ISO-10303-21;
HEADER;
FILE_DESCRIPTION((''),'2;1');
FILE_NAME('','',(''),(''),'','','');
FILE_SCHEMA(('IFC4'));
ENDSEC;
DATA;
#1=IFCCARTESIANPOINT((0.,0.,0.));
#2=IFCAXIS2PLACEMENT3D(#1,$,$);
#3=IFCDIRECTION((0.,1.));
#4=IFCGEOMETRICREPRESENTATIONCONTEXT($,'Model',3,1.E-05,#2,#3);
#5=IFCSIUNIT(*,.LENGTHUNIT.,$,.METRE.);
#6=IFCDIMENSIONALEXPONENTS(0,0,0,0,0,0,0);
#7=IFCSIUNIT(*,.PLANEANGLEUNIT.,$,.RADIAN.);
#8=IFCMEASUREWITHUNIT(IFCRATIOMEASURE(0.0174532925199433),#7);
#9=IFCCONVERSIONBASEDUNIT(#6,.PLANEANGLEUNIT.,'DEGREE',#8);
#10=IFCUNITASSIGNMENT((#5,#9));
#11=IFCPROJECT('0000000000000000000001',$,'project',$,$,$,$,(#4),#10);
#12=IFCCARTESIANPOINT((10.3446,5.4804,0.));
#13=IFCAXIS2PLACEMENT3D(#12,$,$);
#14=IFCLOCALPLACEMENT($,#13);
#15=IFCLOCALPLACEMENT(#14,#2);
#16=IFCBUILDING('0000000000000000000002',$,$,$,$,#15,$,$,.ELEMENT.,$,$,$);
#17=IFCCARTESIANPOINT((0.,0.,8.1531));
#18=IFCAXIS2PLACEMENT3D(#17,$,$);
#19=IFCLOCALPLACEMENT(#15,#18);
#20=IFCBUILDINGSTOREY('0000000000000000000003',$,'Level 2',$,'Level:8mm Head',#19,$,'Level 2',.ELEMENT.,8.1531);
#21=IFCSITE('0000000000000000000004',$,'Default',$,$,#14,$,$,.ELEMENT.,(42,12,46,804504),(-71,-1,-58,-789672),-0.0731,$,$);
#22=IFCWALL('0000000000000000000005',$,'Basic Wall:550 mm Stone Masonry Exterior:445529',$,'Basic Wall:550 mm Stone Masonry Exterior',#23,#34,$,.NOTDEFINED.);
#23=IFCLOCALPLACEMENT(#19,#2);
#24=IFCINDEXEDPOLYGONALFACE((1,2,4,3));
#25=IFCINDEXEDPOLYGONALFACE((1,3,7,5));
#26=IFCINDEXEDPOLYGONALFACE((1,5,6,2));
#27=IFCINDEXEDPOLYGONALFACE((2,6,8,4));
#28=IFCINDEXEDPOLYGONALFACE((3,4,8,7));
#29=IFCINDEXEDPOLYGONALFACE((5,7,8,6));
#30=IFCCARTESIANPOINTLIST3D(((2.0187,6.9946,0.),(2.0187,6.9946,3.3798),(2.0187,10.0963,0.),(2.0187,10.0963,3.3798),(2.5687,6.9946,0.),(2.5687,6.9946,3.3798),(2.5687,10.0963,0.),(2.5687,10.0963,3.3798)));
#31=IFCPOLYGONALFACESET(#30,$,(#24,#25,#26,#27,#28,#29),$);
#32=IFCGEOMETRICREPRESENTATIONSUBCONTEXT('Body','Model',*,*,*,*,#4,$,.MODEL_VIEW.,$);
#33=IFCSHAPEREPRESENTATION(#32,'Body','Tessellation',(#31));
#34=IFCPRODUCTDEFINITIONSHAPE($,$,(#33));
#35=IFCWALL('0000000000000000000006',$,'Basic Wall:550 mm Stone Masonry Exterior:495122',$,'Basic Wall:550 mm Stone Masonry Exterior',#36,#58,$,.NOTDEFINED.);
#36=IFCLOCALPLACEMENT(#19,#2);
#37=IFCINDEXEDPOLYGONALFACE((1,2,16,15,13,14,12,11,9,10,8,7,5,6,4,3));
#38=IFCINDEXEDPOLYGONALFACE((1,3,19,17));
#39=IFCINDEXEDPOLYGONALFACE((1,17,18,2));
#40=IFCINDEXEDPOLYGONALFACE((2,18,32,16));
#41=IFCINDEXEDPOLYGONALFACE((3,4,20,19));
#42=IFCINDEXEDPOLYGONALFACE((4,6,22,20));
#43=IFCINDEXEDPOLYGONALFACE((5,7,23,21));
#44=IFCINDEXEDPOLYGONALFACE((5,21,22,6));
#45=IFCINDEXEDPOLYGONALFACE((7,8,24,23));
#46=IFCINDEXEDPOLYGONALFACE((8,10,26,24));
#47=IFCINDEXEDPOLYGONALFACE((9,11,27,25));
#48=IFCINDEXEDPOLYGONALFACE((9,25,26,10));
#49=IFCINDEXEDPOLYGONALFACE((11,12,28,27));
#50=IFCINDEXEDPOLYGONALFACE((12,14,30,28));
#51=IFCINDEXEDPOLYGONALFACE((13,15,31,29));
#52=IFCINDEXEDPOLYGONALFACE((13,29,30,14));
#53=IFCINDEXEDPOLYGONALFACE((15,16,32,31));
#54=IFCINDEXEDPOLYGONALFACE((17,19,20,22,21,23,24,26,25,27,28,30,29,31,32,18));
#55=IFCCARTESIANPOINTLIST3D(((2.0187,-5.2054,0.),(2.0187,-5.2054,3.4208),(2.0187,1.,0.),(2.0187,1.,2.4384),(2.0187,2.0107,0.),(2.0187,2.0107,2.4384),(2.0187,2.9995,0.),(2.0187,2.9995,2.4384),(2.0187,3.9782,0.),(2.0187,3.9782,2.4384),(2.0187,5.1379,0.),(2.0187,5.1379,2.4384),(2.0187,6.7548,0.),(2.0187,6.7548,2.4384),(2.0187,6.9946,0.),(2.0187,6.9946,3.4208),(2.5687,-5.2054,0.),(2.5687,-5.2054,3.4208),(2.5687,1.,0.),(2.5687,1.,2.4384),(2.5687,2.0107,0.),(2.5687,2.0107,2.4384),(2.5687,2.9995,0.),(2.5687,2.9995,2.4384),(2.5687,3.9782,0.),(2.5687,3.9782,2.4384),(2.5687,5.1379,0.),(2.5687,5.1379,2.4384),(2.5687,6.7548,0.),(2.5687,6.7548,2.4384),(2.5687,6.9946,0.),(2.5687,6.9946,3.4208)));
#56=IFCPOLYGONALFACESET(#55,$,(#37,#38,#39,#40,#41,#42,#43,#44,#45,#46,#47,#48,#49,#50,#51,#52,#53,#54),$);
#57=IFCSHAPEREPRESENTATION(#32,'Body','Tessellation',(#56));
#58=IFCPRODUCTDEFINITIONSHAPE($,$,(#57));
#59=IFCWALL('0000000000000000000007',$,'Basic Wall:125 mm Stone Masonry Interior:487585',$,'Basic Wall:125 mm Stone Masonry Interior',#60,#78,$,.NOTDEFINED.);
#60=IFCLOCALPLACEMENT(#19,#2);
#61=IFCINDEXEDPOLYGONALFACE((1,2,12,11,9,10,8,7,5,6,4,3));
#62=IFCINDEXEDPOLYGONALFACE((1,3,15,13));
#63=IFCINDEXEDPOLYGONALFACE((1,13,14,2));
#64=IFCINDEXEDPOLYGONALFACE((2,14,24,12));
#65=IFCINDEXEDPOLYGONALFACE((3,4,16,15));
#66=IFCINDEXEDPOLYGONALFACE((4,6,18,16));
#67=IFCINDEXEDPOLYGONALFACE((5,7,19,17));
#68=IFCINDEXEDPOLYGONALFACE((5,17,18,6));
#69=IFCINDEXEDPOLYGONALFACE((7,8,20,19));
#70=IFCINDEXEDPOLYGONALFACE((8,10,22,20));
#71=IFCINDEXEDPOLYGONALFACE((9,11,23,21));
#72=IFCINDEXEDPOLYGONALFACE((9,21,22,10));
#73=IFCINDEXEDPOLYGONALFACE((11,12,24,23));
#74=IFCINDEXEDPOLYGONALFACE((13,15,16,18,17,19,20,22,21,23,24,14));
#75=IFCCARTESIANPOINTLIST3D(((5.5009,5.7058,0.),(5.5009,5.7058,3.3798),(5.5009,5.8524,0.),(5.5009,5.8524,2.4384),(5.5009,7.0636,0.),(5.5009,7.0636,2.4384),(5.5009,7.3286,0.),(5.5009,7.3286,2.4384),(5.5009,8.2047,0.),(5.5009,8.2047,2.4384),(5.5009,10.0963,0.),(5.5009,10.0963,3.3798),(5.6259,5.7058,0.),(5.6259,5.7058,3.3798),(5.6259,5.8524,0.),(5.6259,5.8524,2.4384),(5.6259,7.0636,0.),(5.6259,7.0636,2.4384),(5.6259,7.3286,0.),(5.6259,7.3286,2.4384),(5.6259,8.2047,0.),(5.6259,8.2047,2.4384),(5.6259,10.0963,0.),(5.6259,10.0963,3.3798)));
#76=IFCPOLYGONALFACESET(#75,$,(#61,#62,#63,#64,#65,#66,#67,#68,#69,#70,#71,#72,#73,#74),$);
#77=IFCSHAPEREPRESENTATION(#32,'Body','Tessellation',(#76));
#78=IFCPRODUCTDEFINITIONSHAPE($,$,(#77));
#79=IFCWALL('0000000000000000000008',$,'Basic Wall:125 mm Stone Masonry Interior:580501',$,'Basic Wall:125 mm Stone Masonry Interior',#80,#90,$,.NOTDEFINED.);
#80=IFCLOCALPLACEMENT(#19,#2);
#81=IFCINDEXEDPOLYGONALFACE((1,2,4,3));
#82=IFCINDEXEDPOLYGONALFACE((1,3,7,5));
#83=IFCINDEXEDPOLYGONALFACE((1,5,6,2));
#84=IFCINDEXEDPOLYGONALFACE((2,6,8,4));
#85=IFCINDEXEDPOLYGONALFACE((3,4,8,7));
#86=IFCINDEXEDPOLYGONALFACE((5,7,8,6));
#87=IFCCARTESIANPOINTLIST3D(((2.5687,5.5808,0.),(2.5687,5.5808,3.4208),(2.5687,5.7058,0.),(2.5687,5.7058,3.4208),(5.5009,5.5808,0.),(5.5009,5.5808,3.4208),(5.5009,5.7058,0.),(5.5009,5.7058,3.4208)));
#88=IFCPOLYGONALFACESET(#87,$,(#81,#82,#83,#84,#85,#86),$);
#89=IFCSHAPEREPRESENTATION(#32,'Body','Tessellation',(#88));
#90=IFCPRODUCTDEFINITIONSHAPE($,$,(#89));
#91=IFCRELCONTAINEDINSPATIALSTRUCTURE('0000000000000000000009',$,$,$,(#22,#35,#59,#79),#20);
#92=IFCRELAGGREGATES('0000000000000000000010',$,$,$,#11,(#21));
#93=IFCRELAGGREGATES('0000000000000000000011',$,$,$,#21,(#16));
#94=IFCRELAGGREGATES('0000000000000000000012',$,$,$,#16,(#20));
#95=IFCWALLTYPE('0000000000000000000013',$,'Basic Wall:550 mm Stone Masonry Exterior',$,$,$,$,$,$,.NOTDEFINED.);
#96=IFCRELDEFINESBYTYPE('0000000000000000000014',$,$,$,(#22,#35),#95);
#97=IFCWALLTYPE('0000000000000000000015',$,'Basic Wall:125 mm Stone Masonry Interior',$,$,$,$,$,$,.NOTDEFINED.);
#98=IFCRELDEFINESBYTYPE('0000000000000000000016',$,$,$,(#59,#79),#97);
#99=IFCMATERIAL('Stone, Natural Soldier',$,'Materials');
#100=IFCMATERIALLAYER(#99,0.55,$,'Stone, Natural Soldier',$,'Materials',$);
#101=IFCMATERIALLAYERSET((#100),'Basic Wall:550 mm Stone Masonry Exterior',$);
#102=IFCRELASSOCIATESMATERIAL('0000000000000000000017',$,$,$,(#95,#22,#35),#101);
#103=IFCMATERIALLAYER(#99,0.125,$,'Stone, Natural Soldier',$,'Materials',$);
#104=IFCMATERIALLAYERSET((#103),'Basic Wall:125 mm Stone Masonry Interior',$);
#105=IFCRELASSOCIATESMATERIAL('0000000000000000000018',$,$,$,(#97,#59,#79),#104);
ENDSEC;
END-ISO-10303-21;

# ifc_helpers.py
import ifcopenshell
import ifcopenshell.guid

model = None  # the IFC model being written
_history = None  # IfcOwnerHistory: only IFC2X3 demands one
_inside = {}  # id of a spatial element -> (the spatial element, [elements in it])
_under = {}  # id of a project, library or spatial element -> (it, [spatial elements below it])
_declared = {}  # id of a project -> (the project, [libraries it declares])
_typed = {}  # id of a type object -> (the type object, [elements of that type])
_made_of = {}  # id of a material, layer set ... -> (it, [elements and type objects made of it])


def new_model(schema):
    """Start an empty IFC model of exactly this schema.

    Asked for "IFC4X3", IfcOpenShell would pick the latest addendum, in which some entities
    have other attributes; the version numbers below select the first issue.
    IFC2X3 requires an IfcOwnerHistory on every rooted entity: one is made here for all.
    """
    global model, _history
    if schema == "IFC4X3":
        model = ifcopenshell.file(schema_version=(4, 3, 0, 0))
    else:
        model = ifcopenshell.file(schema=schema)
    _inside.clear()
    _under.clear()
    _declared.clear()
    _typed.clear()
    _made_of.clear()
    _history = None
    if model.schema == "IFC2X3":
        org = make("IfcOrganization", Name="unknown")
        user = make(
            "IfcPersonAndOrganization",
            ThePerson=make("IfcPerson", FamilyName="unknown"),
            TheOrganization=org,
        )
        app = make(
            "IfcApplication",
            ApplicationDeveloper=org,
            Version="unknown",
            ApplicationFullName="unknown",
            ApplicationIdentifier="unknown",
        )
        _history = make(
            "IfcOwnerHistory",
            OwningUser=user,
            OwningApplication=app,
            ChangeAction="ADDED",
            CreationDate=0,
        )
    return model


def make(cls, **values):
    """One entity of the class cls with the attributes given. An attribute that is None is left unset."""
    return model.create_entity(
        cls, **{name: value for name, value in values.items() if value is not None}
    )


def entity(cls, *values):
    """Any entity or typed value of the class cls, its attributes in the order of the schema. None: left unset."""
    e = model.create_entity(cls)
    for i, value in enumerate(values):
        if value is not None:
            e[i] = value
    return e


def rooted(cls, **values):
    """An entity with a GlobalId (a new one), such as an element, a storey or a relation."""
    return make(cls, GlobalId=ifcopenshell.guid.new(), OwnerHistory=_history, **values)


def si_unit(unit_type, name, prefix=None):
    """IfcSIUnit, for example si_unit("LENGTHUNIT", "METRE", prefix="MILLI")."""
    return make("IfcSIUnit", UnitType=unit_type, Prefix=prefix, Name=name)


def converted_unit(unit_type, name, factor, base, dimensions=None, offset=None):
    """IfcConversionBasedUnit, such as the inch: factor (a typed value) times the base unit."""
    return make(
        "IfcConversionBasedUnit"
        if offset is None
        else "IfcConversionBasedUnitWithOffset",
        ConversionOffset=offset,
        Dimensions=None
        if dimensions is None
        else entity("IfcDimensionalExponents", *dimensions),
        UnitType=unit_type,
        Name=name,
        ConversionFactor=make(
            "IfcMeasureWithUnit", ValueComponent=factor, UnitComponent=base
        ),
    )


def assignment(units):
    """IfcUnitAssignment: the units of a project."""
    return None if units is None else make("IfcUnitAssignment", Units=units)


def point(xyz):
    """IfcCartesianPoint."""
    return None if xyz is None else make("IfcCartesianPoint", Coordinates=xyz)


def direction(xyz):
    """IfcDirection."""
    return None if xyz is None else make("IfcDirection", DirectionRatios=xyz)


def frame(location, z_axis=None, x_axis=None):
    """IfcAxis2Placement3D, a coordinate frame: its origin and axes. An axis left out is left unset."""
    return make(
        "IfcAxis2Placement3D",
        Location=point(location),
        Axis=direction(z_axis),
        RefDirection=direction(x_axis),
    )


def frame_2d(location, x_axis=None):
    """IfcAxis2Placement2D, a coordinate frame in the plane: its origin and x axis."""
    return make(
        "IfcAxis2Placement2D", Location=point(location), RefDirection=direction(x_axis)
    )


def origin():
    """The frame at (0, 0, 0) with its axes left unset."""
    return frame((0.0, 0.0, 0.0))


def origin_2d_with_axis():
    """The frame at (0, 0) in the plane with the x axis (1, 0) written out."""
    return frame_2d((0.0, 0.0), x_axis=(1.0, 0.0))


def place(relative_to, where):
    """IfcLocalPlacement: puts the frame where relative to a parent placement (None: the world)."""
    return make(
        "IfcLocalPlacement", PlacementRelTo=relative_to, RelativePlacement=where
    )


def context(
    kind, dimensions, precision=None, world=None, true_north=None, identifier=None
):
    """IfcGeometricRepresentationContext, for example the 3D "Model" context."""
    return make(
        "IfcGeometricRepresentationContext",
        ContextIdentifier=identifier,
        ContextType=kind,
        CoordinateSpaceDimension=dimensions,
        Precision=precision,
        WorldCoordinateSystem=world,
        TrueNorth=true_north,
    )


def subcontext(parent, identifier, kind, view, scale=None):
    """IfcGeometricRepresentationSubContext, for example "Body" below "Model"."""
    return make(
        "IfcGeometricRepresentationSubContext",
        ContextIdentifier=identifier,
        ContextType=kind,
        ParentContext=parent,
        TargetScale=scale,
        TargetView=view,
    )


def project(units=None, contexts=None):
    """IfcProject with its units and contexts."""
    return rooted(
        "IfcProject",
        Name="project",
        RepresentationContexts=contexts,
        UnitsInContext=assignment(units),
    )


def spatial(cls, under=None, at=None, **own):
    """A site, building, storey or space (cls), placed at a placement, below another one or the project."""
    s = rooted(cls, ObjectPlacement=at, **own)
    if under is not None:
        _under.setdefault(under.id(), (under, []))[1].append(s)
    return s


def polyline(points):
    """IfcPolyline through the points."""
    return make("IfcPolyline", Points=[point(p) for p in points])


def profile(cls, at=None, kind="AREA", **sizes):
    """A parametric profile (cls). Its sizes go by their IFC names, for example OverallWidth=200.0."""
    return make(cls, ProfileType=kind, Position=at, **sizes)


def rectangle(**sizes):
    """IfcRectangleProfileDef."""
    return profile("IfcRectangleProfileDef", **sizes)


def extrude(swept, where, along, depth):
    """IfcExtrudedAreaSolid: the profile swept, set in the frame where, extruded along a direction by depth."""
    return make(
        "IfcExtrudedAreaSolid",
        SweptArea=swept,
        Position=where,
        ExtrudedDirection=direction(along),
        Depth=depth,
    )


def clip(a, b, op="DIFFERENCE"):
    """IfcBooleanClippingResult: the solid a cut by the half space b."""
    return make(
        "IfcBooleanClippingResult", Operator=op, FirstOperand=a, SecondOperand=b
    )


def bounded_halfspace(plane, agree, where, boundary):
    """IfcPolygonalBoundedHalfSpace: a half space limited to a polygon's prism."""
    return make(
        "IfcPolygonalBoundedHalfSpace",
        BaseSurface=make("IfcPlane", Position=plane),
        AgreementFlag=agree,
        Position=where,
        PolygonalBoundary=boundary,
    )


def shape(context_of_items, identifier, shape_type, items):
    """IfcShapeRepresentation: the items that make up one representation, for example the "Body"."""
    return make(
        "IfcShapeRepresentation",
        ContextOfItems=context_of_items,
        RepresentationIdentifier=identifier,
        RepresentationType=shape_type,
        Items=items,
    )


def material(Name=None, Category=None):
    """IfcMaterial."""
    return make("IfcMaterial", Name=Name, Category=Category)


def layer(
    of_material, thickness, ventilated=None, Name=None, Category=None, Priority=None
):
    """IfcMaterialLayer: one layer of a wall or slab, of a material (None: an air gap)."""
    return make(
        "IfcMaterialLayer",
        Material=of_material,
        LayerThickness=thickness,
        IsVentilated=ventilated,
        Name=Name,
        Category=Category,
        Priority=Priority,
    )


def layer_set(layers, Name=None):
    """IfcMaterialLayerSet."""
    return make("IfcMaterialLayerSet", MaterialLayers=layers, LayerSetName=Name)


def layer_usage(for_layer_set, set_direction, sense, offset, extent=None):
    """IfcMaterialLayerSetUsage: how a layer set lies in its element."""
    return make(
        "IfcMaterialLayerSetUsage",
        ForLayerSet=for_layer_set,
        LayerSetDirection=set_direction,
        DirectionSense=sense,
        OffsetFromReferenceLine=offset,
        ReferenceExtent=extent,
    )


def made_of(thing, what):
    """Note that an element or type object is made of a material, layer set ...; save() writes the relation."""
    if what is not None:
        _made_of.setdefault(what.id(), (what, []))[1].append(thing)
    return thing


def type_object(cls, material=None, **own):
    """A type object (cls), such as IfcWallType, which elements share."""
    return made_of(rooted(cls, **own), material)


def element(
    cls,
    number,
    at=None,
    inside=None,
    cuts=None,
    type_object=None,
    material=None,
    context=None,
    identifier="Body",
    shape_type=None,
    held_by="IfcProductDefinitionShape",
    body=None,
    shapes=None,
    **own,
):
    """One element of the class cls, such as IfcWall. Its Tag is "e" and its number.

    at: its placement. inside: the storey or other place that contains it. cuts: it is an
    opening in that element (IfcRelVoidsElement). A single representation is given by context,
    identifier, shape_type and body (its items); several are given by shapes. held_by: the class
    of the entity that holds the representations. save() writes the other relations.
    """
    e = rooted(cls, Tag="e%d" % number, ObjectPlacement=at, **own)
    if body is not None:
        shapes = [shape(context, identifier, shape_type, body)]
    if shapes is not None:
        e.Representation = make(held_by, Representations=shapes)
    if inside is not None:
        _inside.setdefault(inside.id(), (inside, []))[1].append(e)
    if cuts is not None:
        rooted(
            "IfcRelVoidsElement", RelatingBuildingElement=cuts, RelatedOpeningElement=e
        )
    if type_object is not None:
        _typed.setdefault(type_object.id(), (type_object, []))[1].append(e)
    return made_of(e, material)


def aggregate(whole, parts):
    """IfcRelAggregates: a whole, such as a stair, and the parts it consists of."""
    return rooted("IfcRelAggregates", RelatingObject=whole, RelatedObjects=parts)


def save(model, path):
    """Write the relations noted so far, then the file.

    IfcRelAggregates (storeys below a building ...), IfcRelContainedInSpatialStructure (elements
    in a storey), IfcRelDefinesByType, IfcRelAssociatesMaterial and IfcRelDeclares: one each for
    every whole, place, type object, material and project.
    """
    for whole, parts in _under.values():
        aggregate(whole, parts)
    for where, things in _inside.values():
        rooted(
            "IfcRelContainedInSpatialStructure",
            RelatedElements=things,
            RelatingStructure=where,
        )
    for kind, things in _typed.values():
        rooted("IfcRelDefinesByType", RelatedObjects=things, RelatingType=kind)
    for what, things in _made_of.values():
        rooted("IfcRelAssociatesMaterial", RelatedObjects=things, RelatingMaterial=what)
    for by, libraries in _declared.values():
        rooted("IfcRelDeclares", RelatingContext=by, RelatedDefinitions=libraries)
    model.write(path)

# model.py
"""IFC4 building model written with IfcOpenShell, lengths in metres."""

from ifc_helpers import new_model, entity, si_unit, converted_unit, direction, frame, frame_2d, origin, origin_2d_with_axis, place, context, subcontext, project, spatial, polyline, rectangle, extrude, clip, bounded_halfspace, material, layer, layer_set, layer_usage, type_object, element, save


model = new_model("IFC4")

# Units and contexts
model_context = context("Model", 3, precision=1e-05, world=origin(), true_north=direction((0.0, 1.0)))
body_context = subcontext(model_context, "Body", "Model", "MODEL_VIEW")
ifc_project = project(units=[si_unit("LENGTHUNIT", "METRE"), converted_unit("PLANEANGLEUNIT", "DEGREE", entity("IfcRatioMeasure", 0.0174532925199433), si_unit("PLANEANGLEUNIT", "RADIAN"), dimensions=[0, 0, 0, 0, 0, 0, 0])], contexts=[model_context])

# Site, building, storey
site_placement = place(None, frame((10.3446, 5.4804, 0.0)))
site = spatial("IfcSite", under=ifc_project, at=site_placement, Name="Default", CompositionType="ELEMENT", RefLatitude=(42, 12, 46, 804504), RefLongitude=(-71, -1, -58, -789672), RefElevation=-0.0731)
building_placement = place(site_placement, origin())
building = spatial("IfcBuilding", under=site, at=building_placement, CompositionType="ELEMENT")
storey_placement = place(building_placement, frame((0.0, 0.0, 8.1531)))
storey = spatial("IfcBuildingStorey", under=building, at=storey_placement, Name="Level 2", ObjectType="Level:8mm Head", LongName="Level 2", CompositionType="ELEMENT", Elevation=8.1531)

# Wall
ifc_material_1 = material(Name="Stone, Natural Soldier", Category="Materials")
ifc_layer_1 = layer(ifc_material_1, 0.55, Name="Stone, Natural Soldier", Category="Materials")
ifc_layer_set_1 = layer_set([ifc_layer_1], Name="Basic Wall:550 mm Stone Masonry Exterior")
ifc_layer_usage_1 = layer_usage(ifc_layer_set_1, "AXIS2", "NEGATIVE", 0.275)
wall_type_1 = type_object("IfcWallType", Name="Basic Wall:550 mm Stone Masonry Exterior", PredefinedType="NOTDEFINED", material=ifc_layer_set_1)
wall_1_placement = place(storey_placement, frame((2.2937, 10.0963, 0.0), z_axis=(0.0, 0.0, 1.0), x_axis=(0.0, -1.0, 0.0)))
element("IfcWall", 1, at=wall_1_placement, inside=storey, type_object=wall_type_1, material=ifc_layer_usage_1, Name="Basic Wall:550 mm Stone Masonry Exterior:445529", ObjectType="Basic Wall:550 mm Stone Masonry Exterior", PredefinedType="NOTDEFINED", context=body_context, shape_type="SweptSolid", body=[
    extrude(rectangle(XDim=3.1017, YDim=0.55, at=frame_2d((1.5509, 0.0), x_axis=(-1.0, 0.0))), origin(), (0.0, 0.0, 1.0), 3.3798),
])

# Walls, openings
ifc_layer_usage_2 = layer_usage(ifc_layer_set_1, "AXIS2", "NEGATIVE", 0.275)
wall_2_placement = place(storey_placement, frame((2.2937, 6.9946, 0.0), z_axis=(0.0, 0.0, 1.0), x_axis=(0.0, -1.0, 0.0)))
wall_2 = element("IfcWall", 2, at=wall_2_placement, inside=storey, type_object=wall_type_1, material=ifc_layer_usage_2, Name="Basic Wall:550 mm Stone Masonry Exterior:495122", ObjectType="Basic Wall:550 mm Stone Masonry Exterior", PredefinedType="NOTDEFINED", context=body_context, shape_type="SweptSolid", body=[
    extrude(rectangle(XDim=12.2, YDim=0.55, at=frame_2d((6.1, 0.0), x_axis=(-1.0, 0.0))), origin(), (0.0, 0.0, 1.0), 3.4208),
])
opening_1_placement = place(wall_2_placement, frame((1.8567, -0.275, 0.0)))
element("IfcOpeningElement", 3, at=opening_1_placement, cuts=wall_2, ObjectType="Opening", PredefinedType="OPENING", context=body_context, shape_type="SweptSolid", body=[
    extrude(rectangle(XDim=2.4384, YDim=1.6169, at=origin_2d_with_axis()), frame((-0.8084, 0.0, 1.2192), z_axis=(0.0, 1.0, 0.0), x_axis=(0.0, 0.0, -1.0)), (0.0, 0.0, 1.0), 0.55),
])
opening_2_placement = place(wall_2_placement, frame((3.9951, -0.275, 0.0)))
element("IfcOpeningElement", 4, at=opening_2_placement, cuts=wall_2, ObjectType="Opening", PredefinedType="OPENING", context=body_context, shape_type="SweptSolid", body=[
    extrude(rectangle(XDim=2.4384, YDim=0.9787, at=origin_2d_with_axis()), frame((-0.4893, 0.0, 1.2192), z_axis=(0.0, 1.0, 0.0), x_axis=(0.0, 0.0, -1.0)), (0.0, 0.0, 1.0), 0.55),
])
opening_3_placement = place(wall_2_placement, frame((5.9946, -0.275, 0.0)))
element("IfcOpeningElement", 5, at=opening_3_placement, cuts=wall_2, ObjectType="Opening", PredefinedType="OPENING", context=body_context, shape_type="SweptSolid", body=[
    extrude(rectangle(XDim=2.4384, YDim=1.0107, at=origin_2d_with_axis()), frame((-0.5053, 0.0, 1.2192), z_axis=(0.0, 1.0, 0.0), x_axis=(0.0, 0.0, -1.0)), (0.0, 0.0, 1.0), 0.55),
])
ifc_layer_2 = layer(ifc_material_1, 0.125, Name="Stone, Natural Soldier", Category="Materials")
ifc_layer_set_2 = layer_set([ifc_layer_2], Name="Basic Wall:125 mm Stone Masonry Interior")
ifc_layer_usage_3 = layer_usage(ifc_layer_set_2, "AXIS2", "NEGATIVE", 0.0625)
wall_type_2 = type_object("IfcWallType", Name="Basic Wall:125 mm Stone Masonry Interior", PredefinedType="NOTDEFINED", material=ifc_layer_set_2)
wall_3_placement = place(storey_placement, frame((5.5634, 5.7058, 0.0), z_axis=(0.0, 0.0, 1.0), x_axis=(0.0, 1.0, 0.0)))
wall_3 = element("IfcWall", 6, at=wall_3_placement, inside=storey, type_object=wall_type_2, material=ifc_layer_usage_3, Name="Basic Wall:125 mm Stone Masonry Interior:487585", ObjectType="Basic Wall:125 mm Stone Masonry Interior", PredefinedType="NOTDEFINED", context=body_context, shape_type="Clipping", body=[
    clip(extrude(rectangle(XDim=4.3905, YDim=0.125, at=frame_2d((2.1953, 0.0), x_axis=(-1.0, 0.0))), origin(), (0.0, 0.0, 1.0), 3.3798), bounded_halfspace(frame((0.0, -0.0625, 3.3798), z_axis=(0.0, 0.0, -1.0), x_axis=(-0.978148, 0.207912, 0.0)), True, frame((0.0, -0.0625, 3.3798)), polyline([(0.0, 0.0), (4.3905, 0.0), (4.3905, 0.125), (0.0, 0.125), (0.0, 0.0)]))),
])
opening_4_placement = place(wall_3_placement, frame((1.6228, 0.0625, 0.0)))
element("IfcOpeningElement", 7, at=opening_4_placement, cuts=wall_3, ObjectType="Opening", PredefinedType="OPENING", context=body_context, shape_type="SweptSolid", body=[
    extrude(rectangle(XDim=2.4384, YDim=0.8761, at=origin_2d_with_axis()), frame((0.4381, -0.125, 1.2192), z_axis=(0.0, 1.0, 0.0), x_axis=(0.0, 0.0, -1.0)), (0.0, 0.0, 1.0), 0.125),
])
opening_5_placement = place(wall_3_placement, frame((0.1466, 0.0625, 0.0)))
element("IfcOpeningElement", 8, at=opening_5_placement, cuts=wall_3, ObjectType="Opening", PredefinedType="OPENING", context=body_context, shape_type="SweptSolid", body=[
    extrude(rectangle(XDim=2.4384, YDim=1.2112, at=frame_2d((0.0, 0.0), x_axis=(1.0, 0.0))), frame((0.6056, -0.125, 1.2192), z_axis=(0.0, 1.0, 0.0), x_axis=(0.0, 0.0, -1.0)), (0.0, 0.0, 1.0), 0.125),
])

# Wall
ifc_layer_usage_4 = layer_usage(ifc_layer_set_2, "AXIS2", "NEGATIVE", 0.0625)
wall_4_placement = place(storey_placement, frame((5.5009, 5.6433, 0.0), z_axis=(0.0, 0.0, 1.0), x_axis=(-1.0, 0.0, 0.0)))
element("IfcWall", 9, at=wall_4_placement, inside=storey, type_object=wall_type_2, material=ifc_layer_usage_4, Name="Basic Wall:125 mm Stone Masonry Interior:580501", ObjectType="Basic Wall:125 mm Stone Masonry Interior", PredefinedType="NOTDEFINED", context=body_context, shape_type="SweptSolid", body=[
    extrude(rectangle(XDim=2.9322, YDim=0.125, at=frame_2d((1.4661, 0.0), x_axis=(-1.0, 0.0))), origin(), (0.0, 0.0, 1.0), 3.4208),
])

save(model, "model.ifc")
